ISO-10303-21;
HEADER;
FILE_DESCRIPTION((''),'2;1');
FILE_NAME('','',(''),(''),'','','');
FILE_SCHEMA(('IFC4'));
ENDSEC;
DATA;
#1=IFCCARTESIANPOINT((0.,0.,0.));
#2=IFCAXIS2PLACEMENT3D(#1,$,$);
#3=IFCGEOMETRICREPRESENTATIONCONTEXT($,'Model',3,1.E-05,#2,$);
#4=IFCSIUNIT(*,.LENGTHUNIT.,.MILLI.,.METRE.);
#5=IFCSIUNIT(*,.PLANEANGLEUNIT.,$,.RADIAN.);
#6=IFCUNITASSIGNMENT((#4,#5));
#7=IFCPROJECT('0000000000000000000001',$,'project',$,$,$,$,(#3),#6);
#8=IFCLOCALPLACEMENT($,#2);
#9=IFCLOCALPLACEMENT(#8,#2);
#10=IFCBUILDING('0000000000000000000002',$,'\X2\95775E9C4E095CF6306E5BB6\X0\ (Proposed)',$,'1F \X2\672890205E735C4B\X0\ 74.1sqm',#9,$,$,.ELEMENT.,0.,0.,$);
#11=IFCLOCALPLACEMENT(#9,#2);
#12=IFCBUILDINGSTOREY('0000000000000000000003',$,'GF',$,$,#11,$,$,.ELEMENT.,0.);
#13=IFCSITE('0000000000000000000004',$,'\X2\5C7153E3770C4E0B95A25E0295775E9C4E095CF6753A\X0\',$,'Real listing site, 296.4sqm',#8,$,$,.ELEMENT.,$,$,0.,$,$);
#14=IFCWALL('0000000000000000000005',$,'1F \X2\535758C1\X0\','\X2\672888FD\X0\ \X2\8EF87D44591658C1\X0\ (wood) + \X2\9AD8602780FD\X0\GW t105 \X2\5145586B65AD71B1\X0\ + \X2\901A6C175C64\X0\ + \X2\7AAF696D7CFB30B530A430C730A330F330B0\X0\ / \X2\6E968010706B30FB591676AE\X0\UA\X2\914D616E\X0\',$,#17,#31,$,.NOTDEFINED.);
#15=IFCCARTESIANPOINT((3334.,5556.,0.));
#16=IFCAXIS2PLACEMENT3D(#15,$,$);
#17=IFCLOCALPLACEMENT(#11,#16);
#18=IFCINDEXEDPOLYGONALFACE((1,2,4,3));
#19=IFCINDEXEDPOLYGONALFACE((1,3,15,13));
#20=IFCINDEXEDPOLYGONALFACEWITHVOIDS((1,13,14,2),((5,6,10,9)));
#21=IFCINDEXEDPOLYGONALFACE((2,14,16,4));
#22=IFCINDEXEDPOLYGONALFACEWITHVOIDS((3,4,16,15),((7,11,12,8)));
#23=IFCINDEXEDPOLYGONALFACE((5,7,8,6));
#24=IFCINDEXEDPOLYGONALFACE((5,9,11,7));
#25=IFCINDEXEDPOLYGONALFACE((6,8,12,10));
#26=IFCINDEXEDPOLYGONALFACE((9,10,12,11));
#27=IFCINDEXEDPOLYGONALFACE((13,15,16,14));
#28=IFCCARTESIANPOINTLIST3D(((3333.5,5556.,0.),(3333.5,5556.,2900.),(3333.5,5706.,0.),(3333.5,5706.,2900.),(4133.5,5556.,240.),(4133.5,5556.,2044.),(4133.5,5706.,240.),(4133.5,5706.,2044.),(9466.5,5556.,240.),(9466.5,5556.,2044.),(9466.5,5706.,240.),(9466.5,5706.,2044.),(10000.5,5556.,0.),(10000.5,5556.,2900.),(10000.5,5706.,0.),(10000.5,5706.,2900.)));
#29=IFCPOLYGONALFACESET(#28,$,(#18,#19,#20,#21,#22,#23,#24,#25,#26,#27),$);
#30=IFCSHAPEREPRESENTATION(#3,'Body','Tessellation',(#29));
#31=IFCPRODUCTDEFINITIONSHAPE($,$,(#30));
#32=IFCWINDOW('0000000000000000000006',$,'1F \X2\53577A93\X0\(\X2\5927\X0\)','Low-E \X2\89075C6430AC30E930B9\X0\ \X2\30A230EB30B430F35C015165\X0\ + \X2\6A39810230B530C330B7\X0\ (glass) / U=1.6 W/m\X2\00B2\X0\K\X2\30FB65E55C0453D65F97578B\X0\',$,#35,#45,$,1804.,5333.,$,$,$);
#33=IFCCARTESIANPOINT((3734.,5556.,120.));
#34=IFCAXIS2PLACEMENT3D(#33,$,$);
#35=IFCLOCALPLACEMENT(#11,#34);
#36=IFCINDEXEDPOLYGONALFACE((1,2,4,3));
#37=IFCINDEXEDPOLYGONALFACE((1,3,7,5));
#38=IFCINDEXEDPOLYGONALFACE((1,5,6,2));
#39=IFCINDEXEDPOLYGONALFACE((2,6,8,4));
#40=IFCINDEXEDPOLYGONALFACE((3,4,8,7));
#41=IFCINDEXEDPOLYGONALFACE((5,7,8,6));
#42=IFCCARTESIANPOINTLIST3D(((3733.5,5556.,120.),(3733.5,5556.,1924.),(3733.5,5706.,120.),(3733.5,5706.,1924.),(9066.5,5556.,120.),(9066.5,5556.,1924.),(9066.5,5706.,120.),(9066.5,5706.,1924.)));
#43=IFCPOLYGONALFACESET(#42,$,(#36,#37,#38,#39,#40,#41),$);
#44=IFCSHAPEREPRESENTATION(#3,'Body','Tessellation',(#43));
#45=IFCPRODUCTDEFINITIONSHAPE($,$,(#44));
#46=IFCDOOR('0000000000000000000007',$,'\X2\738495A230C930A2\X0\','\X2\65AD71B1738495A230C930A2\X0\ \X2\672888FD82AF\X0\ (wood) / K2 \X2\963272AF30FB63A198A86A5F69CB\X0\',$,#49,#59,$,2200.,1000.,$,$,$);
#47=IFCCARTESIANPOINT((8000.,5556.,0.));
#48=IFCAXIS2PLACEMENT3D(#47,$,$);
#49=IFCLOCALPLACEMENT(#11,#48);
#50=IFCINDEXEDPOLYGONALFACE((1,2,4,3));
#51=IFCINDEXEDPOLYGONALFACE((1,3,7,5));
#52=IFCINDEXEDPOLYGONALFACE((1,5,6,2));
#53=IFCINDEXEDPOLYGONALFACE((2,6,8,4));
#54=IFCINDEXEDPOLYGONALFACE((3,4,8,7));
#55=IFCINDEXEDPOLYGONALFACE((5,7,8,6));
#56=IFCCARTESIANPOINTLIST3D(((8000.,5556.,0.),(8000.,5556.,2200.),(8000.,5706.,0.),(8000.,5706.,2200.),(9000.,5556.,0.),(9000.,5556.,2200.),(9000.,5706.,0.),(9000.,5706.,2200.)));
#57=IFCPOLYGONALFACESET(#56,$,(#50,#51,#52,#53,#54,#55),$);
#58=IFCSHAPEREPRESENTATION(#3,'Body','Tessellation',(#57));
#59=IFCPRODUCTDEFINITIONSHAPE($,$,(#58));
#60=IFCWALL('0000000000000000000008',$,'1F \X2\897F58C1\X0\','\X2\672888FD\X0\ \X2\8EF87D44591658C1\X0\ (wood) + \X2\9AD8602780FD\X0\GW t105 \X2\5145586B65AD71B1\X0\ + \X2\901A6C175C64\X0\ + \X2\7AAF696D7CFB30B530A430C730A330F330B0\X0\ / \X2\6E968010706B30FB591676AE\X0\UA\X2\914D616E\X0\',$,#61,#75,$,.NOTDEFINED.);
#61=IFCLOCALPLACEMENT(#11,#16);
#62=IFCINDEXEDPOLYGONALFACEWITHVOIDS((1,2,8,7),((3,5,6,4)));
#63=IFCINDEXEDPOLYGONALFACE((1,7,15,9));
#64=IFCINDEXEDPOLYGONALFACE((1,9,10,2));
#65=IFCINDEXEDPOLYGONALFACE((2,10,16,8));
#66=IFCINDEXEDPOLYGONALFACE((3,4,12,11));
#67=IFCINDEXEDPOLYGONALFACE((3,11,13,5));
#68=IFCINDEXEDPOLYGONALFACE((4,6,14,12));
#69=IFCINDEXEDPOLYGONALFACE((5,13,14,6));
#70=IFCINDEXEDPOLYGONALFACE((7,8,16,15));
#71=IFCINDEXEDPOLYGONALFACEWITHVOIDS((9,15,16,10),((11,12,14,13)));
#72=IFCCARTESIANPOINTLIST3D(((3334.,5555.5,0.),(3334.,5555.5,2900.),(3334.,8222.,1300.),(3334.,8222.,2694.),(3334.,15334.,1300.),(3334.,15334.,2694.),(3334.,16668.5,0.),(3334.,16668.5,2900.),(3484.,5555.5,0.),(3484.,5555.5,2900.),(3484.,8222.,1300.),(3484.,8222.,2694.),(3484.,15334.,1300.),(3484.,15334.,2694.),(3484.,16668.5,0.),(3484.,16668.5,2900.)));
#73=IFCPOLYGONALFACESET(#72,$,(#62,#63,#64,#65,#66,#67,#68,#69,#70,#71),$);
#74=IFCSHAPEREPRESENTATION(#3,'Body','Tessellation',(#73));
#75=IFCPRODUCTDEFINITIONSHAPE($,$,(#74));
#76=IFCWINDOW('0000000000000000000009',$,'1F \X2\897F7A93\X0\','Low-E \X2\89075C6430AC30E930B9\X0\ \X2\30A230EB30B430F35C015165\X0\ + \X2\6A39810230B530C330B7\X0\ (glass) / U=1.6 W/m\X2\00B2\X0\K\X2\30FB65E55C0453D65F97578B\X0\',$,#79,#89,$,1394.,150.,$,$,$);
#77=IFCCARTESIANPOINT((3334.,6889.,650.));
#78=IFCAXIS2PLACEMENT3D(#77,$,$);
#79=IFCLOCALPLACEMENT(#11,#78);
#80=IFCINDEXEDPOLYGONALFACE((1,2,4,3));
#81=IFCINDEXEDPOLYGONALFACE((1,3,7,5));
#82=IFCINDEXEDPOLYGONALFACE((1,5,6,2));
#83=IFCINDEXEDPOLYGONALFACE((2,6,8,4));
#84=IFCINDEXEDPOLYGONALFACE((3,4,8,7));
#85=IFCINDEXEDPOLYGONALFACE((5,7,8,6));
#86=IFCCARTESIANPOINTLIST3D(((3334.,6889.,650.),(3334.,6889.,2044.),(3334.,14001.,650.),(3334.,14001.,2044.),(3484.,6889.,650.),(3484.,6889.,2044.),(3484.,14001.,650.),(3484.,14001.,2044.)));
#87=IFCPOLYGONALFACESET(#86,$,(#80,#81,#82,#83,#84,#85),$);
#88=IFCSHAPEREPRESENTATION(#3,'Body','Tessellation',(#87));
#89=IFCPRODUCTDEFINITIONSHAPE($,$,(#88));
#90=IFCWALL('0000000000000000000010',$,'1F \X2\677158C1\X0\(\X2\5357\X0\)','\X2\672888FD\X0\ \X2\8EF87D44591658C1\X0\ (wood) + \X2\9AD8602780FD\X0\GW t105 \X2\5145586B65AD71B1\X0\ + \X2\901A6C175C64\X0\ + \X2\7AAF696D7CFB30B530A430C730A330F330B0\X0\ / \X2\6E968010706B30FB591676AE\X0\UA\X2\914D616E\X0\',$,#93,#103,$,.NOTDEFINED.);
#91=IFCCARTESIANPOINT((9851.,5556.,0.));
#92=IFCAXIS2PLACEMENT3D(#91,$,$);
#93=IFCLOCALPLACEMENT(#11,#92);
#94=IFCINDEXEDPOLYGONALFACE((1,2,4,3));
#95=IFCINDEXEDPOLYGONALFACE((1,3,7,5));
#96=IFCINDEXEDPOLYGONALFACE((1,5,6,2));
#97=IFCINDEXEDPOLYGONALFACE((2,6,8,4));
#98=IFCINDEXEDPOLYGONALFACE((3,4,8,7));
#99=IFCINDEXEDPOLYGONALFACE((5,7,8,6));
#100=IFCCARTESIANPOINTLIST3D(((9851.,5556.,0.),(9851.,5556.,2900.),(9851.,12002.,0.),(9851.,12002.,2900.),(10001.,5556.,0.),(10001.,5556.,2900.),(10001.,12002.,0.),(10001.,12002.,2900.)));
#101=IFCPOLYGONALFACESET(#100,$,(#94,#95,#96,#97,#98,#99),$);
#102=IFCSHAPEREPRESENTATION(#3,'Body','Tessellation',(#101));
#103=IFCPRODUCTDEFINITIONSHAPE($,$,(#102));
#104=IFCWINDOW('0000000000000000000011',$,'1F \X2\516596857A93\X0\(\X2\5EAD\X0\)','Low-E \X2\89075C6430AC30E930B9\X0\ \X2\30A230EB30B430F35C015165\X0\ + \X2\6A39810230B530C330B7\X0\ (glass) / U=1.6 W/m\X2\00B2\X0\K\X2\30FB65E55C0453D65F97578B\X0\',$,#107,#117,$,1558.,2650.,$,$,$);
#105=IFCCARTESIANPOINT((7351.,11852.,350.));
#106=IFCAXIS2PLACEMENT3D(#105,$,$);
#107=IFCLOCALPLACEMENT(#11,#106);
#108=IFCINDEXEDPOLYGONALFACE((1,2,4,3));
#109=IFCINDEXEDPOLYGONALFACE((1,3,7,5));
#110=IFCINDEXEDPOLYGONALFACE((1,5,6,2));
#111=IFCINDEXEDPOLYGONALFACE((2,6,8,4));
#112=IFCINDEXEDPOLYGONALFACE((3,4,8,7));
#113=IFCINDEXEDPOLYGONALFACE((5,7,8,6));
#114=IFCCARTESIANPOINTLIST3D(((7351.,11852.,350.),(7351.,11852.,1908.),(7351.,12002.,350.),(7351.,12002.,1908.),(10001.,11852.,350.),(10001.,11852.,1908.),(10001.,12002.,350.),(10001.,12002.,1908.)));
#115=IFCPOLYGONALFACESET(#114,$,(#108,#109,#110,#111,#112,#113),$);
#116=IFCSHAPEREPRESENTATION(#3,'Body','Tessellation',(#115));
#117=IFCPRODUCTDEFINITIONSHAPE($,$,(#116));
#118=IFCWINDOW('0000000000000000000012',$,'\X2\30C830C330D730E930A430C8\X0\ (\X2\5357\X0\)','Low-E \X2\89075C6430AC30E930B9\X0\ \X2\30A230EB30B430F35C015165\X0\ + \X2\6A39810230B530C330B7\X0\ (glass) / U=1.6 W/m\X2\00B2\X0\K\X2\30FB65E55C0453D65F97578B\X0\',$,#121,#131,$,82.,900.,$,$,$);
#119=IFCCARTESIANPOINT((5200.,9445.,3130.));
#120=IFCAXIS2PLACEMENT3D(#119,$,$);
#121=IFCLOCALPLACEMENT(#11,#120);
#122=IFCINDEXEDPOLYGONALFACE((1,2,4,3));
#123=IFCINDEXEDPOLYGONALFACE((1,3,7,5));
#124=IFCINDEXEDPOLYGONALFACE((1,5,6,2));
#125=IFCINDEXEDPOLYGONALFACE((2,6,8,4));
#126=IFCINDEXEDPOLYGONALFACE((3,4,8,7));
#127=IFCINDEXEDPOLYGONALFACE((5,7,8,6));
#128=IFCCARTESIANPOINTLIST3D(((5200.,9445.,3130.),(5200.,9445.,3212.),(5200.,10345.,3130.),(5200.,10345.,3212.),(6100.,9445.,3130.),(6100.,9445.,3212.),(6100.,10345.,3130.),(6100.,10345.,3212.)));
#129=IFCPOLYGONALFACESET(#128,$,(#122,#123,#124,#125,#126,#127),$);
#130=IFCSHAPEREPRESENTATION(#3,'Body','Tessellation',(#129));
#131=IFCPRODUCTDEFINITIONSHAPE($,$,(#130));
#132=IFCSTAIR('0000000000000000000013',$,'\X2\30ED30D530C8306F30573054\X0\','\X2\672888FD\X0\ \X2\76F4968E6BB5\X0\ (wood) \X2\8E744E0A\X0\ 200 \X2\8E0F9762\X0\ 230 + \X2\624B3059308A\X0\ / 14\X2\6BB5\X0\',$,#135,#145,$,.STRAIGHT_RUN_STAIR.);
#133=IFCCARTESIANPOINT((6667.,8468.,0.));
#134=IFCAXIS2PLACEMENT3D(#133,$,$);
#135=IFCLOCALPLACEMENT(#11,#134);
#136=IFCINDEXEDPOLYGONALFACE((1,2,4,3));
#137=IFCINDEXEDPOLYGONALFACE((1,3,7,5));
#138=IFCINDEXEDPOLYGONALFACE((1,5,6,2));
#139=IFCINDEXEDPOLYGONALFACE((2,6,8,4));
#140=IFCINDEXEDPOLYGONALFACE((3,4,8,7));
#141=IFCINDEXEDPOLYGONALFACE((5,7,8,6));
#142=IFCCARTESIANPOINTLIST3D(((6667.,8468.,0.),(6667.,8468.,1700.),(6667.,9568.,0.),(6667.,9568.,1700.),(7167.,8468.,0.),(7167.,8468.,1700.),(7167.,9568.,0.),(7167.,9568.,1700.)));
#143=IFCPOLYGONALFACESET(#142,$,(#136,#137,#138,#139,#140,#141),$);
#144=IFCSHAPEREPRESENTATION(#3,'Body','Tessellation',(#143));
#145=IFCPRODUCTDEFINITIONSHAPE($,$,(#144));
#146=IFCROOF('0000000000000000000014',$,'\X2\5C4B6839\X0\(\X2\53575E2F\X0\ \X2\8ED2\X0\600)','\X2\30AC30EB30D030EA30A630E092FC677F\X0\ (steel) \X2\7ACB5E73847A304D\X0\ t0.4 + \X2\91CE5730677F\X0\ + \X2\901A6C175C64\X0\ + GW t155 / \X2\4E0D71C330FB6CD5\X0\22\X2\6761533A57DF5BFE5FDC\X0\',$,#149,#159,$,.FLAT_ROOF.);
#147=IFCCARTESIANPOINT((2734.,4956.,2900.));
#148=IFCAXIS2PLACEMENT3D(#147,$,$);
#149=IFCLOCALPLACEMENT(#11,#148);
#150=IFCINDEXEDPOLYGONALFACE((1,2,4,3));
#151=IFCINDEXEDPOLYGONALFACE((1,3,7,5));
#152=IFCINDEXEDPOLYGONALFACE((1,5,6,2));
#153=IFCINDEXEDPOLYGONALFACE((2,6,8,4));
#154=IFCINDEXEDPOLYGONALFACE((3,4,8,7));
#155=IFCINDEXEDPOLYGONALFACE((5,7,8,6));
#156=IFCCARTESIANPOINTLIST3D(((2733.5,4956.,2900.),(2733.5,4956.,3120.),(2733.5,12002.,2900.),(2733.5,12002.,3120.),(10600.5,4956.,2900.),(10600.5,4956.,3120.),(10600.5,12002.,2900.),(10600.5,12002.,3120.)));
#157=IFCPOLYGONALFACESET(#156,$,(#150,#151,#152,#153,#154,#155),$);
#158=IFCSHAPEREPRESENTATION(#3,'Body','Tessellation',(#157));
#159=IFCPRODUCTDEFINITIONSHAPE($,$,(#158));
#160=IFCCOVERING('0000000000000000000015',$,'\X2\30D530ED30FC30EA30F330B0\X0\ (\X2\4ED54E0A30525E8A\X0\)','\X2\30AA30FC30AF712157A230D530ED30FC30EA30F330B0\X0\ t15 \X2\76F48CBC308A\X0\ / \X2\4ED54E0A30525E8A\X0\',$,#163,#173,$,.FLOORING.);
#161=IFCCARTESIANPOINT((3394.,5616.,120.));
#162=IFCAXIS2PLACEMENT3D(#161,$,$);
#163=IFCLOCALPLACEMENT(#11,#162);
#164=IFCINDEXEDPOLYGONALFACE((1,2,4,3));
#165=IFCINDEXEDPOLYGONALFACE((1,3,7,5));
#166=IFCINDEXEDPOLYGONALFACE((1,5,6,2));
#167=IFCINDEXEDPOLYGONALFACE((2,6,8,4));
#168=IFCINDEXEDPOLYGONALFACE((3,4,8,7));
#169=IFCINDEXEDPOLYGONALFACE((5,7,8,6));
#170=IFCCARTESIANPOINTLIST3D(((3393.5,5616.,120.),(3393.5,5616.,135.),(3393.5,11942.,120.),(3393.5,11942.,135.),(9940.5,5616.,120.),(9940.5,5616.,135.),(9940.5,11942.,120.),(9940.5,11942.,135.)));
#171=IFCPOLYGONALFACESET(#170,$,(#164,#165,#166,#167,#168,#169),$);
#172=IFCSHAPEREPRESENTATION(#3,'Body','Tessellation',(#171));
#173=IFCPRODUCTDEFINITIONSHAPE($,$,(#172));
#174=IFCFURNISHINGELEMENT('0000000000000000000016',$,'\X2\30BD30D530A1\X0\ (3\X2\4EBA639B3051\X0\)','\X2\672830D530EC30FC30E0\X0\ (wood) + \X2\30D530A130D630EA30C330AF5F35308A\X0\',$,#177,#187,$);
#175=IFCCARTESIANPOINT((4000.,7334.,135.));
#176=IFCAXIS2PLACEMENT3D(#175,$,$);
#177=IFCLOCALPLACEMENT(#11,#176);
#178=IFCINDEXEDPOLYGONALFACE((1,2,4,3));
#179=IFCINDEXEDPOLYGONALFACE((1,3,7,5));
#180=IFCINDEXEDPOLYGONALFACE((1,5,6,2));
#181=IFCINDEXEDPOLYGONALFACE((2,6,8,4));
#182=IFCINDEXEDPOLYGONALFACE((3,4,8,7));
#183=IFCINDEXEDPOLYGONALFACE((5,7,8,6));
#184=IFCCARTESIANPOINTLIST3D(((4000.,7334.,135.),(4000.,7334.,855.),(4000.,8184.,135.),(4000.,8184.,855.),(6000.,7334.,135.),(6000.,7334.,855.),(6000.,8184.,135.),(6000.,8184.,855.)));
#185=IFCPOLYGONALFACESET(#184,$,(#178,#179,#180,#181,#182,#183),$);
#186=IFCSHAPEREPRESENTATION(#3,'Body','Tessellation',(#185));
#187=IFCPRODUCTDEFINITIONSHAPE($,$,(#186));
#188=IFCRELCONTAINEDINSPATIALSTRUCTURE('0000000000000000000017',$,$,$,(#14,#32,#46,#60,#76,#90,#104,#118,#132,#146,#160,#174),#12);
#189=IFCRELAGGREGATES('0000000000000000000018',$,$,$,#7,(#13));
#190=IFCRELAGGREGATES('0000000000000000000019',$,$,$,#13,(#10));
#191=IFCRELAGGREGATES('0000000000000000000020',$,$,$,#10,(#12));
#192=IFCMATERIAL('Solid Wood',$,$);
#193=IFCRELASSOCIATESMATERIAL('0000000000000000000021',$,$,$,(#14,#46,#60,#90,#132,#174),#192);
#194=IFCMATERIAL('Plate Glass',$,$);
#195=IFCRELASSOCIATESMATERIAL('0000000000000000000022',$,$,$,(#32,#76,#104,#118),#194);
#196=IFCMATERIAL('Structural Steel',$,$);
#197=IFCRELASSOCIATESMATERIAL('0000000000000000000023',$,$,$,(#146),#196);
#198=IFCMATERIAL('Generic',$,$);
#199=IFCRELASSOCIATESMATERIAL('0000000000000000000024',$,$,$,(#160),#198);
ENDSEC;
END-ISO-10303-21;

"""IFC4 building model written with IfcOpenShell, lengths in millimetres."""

from ifc_helpers import new_model, si_unit, frame, frame_2d, origin, place, context, project, spatial, rectangle, extrude, material, element, fill, save


model = new_model("IFC4")

# Units and contexts
model_context = context("Model", 3, precision=1e-05, world=origin())
ifc_project = project(units=[si_unit("LENGTHUNIT", "METRE", prefix="MILLI"), si_unit("PLANEANGLEUNIT", "RADIAN")], contexts=[model_context])

# Site, building, storey
site_placement = place(None, origin())
site = spatial("IfcSite", under=ifc_project, at=site_placement, Name="山口県下関市長府三島町", ObjectType="Real listing site, 296.4sqm", CompositionType="ELEMENT", RefElevation=0.0)
building_placement = place(site_placement, origin())
building = spatial("IfcBuilding", under=site, at=building_placement, Name="長府三島の家 (Proposed)", ObjectType="1F 木造平屋 74.1sqm", CompositionType="ELEMENT", ElevationOfRefHeight=0.0, ElevationOfTerrain=0.0)
storey_placement = place(building_placement, origin())
storey = spatial("IfcBuildingStorey", under=building, at=storey_placement, Name="GF", CompositionType="ELEMENT", Elevation=0.0)

# Shared definitions
ifc_material_1 = material(Name="Solid Wood")

# Wall, openings, window, door
wall_1_placement = place(storey_placement, frame((3334.0, 5556.0, 0.0)))
wall_1 = element("IfcWall", 1, at=wall_1_placement, inside=storey, material=ifc_material_1, Name="1F 南壁", Description="木製 軸組外壁 (wood) + 高性能GW t105 充填断熱 + 通気層 + 窯業系サイディング / 準耐火・外皮UA配慮", PredefinedType="NOTDEFINED", context=model_context, shape_type="SweptSolid", body=[
    extrude(rectangle(XDim=6667.0, YDim=150.0, at=frame_2d((3333.0, 75.0))), frame((3334.0, 5556.0, 0.0)), (0.0, 0.0, 1.0), 2900.0),
])
opening_1_placement = place(storey_placement, frame((3734.0, 5556.0, 120.0)))
opening_1 = element("IfcOpeningElement", 2, at=opening_1_placement, cuts=wall_1, PredefinedType="NOTDEFINED", context=model_context, shape_type="SweptSolid", body=[
    extrude(rectangle(XDim=5333.0, YDim=150.0, at=frame_2d((2666.0, 75.0))), frame((3734.0, 5556.0, 120.0)), (0.0, 0.0, 1.0), 1804.0),
])
opening_2_placement = place(storey_placement, frame((8000.0, 5556.0, 0.0)))
opening_2 = element("IfcOpeningElement", 3, at=opening_2_placement, cuts=wall_1, PredefinedType="NOTDEFINED", context=model_context, shape_type="SweptSolid", body=[
    extrude(rectangle(XDim=1000.0, YDim=150.0, at=frame_2d((500.0, 75.0))), frame((8000.0, 5556.0, 0.0)), (0.0, 0.0, 1.0), 2200.0),
])
ifc_material_2 = material(Name="Plate Glass")
window_1_placement = place(storey_placement, frame((3734.0, 5556.0, 120.0)))
window_1 = element("IfcWindow", 4, at=window_1_placement, inside=storey, material=ifc_material_2, Name="1F 南窓(大)", Description="Low-E 複層ガラス アルゴン封入 + 樹脂サッシ (glass) / U=1.6 W/m²K・日射取得型", OverallHeight=1804.0, OverallWidth=5333.0, context=model_context, shape_type="SweptSolid", body=[
    extrude(rectangle(XDim=5333.0, YDim=150.0, at=frame_2d((2666.0, 75.0))), frame((3734.0, 5556.0, 120.0)), (0.0, 0.0, 1.0), 1804.0),
])
fill(opening_1, window_1)
door_1_placement = place(storey_placement, frame((8000.0, 5556.0, 0.0)))
door_1 = element("IfcDoor", 5, at=door_1_placement, inside=storey, material=ifc_material_1, Name="玄関ドア", Description="断熱玄関ドア 木製芯 (wood) / K2 防犯・採風機構", OverallHeight=2200.0, OverallWidth=1000.0, context=model_context, shape_type="SweptSolid", body=[
    extrude(rectangle(XDim=1000.0, YDim=150.0, at=frame_2d((500.0, 75.0))), frame((8000.0, 5556.0, 0.0)), (0.0, 0.0, 1.0), 2200.0),
])
fill(opening_2, door_1)

# Walls, openings, windows
wall_2_placement = place(storey_placement, frame((3334.0, 5556.0, 0.0)))
wall_2 = element("IfcWall", 6, at=wall_2_placement, inside=storey, material=ifc_material_1, Name="1F 西壁", Description="木製 軸組外壁 (wood) + 高性能GW t105 充填断熱 + 通気層 + 窯業系サイディング / 準耐火・外皮UA配慮", PredefinedType="NOTDEFINED", context=model_context, shape_type="SweptSolid", body=[
    extrude(rectangle(XDim=150.0, YDim=11113.0, at=frame_2d((75.0, 5556.0))), frame((3334.0, 5556.0, 0.0)), (0.0, 0.0, 1.0), 2900.0),
])
opening_3_placement = place(storey_placement, frame((3334.0, 6889.0, 650.0)))
opening_3 = element("IfcOpeningElement", 7, at=opening_3_placement, cuts=wall_2, PredefinedType="NOTDEFINED", context=model_context, shape_type="SweptSolid", body=[
    extrude(rectangle(XDim=150.0, YDim=7112.0, at=frame_2d((75.0, 3556.0))), frame((3334.0, 6889.0, 650.0)), (0.0, 0.0, 1.0), 1394.0),
])
window_2_placement = place(storey_placement, frame((3334.0, 6889.0, 650.0)))
window_2 = element("IfcWindow", 8, at=window_2_placement, inside=storey, material=ifc_material_2, Name="1F 西窓", Description="Low-E 複層ガラス アルゴン封入 + 樹脂サッシ (glass) / U=1.6 W/m²K・日射取得型", OverallHeight=1394.0, OverallWidth=150.0, context=model_context, shape_type="SweptSolid", body=[
    extrude(rectangle(XDim=150.0, YDim=7112.0, at=frame_2d((75.0, 3556.0))), frame((3334.0, 6889.0, 650.0)), (0.0, 0.0, 1.0), 1394.0),
])
fill(opening_3, window_2)
wall_3_placement = place(storey_placement, frame((9851.0, 5556.0, 0.0)))
wall_3 = element("IfcWall", 9, at=wall_3_placement, inside=storey, material=ifc_material_1, Name="1F 東壁(南)", Description="木製 軸組外壁 (wood) + 高性能GW t105 充填断熱 + 通気層 + 窯業系サイディング / 準耐火・外皮UA配慮", PredefinedType="NOTDEFINED", context=model_context, shape_type="SweptSolid", body=[
    extrude(rectangle(XDim=150.0, YDim=6446.0, at=frame_2d((75.0, 3223.0))), frame((9851.0, 5556.0, 0.0)), (0.0, 0.0, 1.0), 2900.0),
])
opening_4_placement = place(storey_placement, frame((7351.0, 11852.0, 350.0)))
opening_4 = element("IfcOpeningElement", 10, at=opening_4_placement, cuts=wall_3, PredefinedType="NOTDEFINED", context=model_context, shape_type="SweptSolid", body=[
    extrude(rectangle(XDim=2650.0, YDim=150.0, at=frame_2d((1325.0, 75.0))), frame((7351.0, 11852.0, 350.0)), (0.0, 0.0, 1.0), 1558.0),
])
window_3_placement = place(storey_placement, frame((7351.0, 11852.0, 350.0)))
window_3 = element("IfcWindow", 11, at=window_3_placement, inside=storey, material=ifc_material_2, Name="1F 入隅窓(庭)", Description="Low-E 複層ガラス アルゴン封入 + 樹脂サッシ (glass) / U=1.6 W/m²K・日射取得型", OverallHeight=1558.0, OverallWidth=2650.0, context=model_context, shape_type="SweptSolid", body=[
    extrude(rectangle(XDim=2650.0, YDim=150.0, at=frame_2d((1325.0, 75.0))), frame((7351.0, 11852.0, 350.0)), (0.0, 0.0, 1.0), 1558.0),
])
fill(opening_4, window_3)

# Window
window_4_placement = place(storey_placement, frame((5200.0, 9445.0, 3130.0)))
element("IfcWindow", 12, at=window_4_placement, inside=storey, material=ifc_material_2, Name="トップライト (南)", Description="Low-E 複層ガラス アルゴン封入 + 樹脂サッシ (glass) / U=1.6 W/m²K・日射取得型", OverallHeight=82.0, OverallWidth=900.0, context=model_context, shape_type="SweptSolid", body=[
    extrude(rectangle(XDim=900.0, YDim=900.0, at=frame_2d((450.0, 450.0))), frame((5200.0, 9445.0, 3130.0)), (0.0, 0.0, 1.0), 82.0),
])

# Stair
stair_placement = place(storey_placement, frame((6667.0, 8468.0, 0.0)))
element("IfcStair", 13, at=stair_placement, inside=storey, material=ifc_material_1, Name="ロフトはしご", Description="木製 直階段 (wood) 蹴上 200 踏面 230 + 手すり / 14段", PredefinedType="STRAIGHT_RUN_STAIR", context=model_context, shape_type="SweptSolid", body=[
    extrude(rectangle(XDim=500.0, YDim=1100.0, at=frame_2d((250.0, 550.0))), frame((6667.0, 8468.0, 0.0)), (0.0, 0.0, 1.0), 1700.0),
])

# Roof
ifc_material_3 = material(Name="Structural Steel")
roof_placement = place(storey_placement, frame((2734.0, 4956.0, 2900.0)))
element("IfcRoof", 14, at=roof_placement, inside=storey, material=ifc_material_3, Name="屋根(南帯 軒600)", Description="ガルバリウム鋼板 (steel) 立平葺き t0.4 + 野地板 + 通気層 + GW t155 / 不燃・法22条区域対応", PredefinedType="FLAT_ROOF", context=model_context, shape_type="SweptSolid", body=[
    extrude(rectangle(XDim=7867.0, YDim=7046.0, at=frame_2d((3933.0, 3523.0))), frame((2734.0, 4956.0, 2900.0)), (0.0, 0.0, 1.0), 220.0),
])

# Covering
ifc_material_4 = material(Name="Generic")
covering_placement = place(storey_placement, frame((3394.0, 5616.0, 120.0)))
element("IfcCovering", 15, at=covering_placement, inside=storey, material=ifc_material_4, Name="フローリング (仕上げ床)", Description="オーク無垢フローリング t15 直貼り / 仕上げ床", PredefinedType="FLOORING", context=model_context, shape_type="SweptSolid", body=[
    extrude(rectangle(XDim=6547.0, YDim=6326.0, at=frame_2d((3273.0, 3163.0))), frame((3394.0, 5616.0, 120.0)), (0.0, 0.0, 1.0), 15.0),
])

# Furnishing element
furnishing_1_placement = place(storey_placement, frame((4000.0, 7334.0, 135.0)))
element("IfcFurnishingElement", 16, at=furnishing_1_placement, inside=storey, material=ifc_material_1, Name="ソファ (3人掛け)", Description="木フレーム (wood) + ファブリック張り", context=model_context, shape_type="SweptSolid", body=[
    extrude(rectangle(XDim=2000.0, YDim=850.0, at=frame_2d((1000.0, 425.0))), frame((4000.0, 7334.0, 135.0)), (0.0, 0.0, 1.0), 720.0),
])

save(model, "model.ifc")
